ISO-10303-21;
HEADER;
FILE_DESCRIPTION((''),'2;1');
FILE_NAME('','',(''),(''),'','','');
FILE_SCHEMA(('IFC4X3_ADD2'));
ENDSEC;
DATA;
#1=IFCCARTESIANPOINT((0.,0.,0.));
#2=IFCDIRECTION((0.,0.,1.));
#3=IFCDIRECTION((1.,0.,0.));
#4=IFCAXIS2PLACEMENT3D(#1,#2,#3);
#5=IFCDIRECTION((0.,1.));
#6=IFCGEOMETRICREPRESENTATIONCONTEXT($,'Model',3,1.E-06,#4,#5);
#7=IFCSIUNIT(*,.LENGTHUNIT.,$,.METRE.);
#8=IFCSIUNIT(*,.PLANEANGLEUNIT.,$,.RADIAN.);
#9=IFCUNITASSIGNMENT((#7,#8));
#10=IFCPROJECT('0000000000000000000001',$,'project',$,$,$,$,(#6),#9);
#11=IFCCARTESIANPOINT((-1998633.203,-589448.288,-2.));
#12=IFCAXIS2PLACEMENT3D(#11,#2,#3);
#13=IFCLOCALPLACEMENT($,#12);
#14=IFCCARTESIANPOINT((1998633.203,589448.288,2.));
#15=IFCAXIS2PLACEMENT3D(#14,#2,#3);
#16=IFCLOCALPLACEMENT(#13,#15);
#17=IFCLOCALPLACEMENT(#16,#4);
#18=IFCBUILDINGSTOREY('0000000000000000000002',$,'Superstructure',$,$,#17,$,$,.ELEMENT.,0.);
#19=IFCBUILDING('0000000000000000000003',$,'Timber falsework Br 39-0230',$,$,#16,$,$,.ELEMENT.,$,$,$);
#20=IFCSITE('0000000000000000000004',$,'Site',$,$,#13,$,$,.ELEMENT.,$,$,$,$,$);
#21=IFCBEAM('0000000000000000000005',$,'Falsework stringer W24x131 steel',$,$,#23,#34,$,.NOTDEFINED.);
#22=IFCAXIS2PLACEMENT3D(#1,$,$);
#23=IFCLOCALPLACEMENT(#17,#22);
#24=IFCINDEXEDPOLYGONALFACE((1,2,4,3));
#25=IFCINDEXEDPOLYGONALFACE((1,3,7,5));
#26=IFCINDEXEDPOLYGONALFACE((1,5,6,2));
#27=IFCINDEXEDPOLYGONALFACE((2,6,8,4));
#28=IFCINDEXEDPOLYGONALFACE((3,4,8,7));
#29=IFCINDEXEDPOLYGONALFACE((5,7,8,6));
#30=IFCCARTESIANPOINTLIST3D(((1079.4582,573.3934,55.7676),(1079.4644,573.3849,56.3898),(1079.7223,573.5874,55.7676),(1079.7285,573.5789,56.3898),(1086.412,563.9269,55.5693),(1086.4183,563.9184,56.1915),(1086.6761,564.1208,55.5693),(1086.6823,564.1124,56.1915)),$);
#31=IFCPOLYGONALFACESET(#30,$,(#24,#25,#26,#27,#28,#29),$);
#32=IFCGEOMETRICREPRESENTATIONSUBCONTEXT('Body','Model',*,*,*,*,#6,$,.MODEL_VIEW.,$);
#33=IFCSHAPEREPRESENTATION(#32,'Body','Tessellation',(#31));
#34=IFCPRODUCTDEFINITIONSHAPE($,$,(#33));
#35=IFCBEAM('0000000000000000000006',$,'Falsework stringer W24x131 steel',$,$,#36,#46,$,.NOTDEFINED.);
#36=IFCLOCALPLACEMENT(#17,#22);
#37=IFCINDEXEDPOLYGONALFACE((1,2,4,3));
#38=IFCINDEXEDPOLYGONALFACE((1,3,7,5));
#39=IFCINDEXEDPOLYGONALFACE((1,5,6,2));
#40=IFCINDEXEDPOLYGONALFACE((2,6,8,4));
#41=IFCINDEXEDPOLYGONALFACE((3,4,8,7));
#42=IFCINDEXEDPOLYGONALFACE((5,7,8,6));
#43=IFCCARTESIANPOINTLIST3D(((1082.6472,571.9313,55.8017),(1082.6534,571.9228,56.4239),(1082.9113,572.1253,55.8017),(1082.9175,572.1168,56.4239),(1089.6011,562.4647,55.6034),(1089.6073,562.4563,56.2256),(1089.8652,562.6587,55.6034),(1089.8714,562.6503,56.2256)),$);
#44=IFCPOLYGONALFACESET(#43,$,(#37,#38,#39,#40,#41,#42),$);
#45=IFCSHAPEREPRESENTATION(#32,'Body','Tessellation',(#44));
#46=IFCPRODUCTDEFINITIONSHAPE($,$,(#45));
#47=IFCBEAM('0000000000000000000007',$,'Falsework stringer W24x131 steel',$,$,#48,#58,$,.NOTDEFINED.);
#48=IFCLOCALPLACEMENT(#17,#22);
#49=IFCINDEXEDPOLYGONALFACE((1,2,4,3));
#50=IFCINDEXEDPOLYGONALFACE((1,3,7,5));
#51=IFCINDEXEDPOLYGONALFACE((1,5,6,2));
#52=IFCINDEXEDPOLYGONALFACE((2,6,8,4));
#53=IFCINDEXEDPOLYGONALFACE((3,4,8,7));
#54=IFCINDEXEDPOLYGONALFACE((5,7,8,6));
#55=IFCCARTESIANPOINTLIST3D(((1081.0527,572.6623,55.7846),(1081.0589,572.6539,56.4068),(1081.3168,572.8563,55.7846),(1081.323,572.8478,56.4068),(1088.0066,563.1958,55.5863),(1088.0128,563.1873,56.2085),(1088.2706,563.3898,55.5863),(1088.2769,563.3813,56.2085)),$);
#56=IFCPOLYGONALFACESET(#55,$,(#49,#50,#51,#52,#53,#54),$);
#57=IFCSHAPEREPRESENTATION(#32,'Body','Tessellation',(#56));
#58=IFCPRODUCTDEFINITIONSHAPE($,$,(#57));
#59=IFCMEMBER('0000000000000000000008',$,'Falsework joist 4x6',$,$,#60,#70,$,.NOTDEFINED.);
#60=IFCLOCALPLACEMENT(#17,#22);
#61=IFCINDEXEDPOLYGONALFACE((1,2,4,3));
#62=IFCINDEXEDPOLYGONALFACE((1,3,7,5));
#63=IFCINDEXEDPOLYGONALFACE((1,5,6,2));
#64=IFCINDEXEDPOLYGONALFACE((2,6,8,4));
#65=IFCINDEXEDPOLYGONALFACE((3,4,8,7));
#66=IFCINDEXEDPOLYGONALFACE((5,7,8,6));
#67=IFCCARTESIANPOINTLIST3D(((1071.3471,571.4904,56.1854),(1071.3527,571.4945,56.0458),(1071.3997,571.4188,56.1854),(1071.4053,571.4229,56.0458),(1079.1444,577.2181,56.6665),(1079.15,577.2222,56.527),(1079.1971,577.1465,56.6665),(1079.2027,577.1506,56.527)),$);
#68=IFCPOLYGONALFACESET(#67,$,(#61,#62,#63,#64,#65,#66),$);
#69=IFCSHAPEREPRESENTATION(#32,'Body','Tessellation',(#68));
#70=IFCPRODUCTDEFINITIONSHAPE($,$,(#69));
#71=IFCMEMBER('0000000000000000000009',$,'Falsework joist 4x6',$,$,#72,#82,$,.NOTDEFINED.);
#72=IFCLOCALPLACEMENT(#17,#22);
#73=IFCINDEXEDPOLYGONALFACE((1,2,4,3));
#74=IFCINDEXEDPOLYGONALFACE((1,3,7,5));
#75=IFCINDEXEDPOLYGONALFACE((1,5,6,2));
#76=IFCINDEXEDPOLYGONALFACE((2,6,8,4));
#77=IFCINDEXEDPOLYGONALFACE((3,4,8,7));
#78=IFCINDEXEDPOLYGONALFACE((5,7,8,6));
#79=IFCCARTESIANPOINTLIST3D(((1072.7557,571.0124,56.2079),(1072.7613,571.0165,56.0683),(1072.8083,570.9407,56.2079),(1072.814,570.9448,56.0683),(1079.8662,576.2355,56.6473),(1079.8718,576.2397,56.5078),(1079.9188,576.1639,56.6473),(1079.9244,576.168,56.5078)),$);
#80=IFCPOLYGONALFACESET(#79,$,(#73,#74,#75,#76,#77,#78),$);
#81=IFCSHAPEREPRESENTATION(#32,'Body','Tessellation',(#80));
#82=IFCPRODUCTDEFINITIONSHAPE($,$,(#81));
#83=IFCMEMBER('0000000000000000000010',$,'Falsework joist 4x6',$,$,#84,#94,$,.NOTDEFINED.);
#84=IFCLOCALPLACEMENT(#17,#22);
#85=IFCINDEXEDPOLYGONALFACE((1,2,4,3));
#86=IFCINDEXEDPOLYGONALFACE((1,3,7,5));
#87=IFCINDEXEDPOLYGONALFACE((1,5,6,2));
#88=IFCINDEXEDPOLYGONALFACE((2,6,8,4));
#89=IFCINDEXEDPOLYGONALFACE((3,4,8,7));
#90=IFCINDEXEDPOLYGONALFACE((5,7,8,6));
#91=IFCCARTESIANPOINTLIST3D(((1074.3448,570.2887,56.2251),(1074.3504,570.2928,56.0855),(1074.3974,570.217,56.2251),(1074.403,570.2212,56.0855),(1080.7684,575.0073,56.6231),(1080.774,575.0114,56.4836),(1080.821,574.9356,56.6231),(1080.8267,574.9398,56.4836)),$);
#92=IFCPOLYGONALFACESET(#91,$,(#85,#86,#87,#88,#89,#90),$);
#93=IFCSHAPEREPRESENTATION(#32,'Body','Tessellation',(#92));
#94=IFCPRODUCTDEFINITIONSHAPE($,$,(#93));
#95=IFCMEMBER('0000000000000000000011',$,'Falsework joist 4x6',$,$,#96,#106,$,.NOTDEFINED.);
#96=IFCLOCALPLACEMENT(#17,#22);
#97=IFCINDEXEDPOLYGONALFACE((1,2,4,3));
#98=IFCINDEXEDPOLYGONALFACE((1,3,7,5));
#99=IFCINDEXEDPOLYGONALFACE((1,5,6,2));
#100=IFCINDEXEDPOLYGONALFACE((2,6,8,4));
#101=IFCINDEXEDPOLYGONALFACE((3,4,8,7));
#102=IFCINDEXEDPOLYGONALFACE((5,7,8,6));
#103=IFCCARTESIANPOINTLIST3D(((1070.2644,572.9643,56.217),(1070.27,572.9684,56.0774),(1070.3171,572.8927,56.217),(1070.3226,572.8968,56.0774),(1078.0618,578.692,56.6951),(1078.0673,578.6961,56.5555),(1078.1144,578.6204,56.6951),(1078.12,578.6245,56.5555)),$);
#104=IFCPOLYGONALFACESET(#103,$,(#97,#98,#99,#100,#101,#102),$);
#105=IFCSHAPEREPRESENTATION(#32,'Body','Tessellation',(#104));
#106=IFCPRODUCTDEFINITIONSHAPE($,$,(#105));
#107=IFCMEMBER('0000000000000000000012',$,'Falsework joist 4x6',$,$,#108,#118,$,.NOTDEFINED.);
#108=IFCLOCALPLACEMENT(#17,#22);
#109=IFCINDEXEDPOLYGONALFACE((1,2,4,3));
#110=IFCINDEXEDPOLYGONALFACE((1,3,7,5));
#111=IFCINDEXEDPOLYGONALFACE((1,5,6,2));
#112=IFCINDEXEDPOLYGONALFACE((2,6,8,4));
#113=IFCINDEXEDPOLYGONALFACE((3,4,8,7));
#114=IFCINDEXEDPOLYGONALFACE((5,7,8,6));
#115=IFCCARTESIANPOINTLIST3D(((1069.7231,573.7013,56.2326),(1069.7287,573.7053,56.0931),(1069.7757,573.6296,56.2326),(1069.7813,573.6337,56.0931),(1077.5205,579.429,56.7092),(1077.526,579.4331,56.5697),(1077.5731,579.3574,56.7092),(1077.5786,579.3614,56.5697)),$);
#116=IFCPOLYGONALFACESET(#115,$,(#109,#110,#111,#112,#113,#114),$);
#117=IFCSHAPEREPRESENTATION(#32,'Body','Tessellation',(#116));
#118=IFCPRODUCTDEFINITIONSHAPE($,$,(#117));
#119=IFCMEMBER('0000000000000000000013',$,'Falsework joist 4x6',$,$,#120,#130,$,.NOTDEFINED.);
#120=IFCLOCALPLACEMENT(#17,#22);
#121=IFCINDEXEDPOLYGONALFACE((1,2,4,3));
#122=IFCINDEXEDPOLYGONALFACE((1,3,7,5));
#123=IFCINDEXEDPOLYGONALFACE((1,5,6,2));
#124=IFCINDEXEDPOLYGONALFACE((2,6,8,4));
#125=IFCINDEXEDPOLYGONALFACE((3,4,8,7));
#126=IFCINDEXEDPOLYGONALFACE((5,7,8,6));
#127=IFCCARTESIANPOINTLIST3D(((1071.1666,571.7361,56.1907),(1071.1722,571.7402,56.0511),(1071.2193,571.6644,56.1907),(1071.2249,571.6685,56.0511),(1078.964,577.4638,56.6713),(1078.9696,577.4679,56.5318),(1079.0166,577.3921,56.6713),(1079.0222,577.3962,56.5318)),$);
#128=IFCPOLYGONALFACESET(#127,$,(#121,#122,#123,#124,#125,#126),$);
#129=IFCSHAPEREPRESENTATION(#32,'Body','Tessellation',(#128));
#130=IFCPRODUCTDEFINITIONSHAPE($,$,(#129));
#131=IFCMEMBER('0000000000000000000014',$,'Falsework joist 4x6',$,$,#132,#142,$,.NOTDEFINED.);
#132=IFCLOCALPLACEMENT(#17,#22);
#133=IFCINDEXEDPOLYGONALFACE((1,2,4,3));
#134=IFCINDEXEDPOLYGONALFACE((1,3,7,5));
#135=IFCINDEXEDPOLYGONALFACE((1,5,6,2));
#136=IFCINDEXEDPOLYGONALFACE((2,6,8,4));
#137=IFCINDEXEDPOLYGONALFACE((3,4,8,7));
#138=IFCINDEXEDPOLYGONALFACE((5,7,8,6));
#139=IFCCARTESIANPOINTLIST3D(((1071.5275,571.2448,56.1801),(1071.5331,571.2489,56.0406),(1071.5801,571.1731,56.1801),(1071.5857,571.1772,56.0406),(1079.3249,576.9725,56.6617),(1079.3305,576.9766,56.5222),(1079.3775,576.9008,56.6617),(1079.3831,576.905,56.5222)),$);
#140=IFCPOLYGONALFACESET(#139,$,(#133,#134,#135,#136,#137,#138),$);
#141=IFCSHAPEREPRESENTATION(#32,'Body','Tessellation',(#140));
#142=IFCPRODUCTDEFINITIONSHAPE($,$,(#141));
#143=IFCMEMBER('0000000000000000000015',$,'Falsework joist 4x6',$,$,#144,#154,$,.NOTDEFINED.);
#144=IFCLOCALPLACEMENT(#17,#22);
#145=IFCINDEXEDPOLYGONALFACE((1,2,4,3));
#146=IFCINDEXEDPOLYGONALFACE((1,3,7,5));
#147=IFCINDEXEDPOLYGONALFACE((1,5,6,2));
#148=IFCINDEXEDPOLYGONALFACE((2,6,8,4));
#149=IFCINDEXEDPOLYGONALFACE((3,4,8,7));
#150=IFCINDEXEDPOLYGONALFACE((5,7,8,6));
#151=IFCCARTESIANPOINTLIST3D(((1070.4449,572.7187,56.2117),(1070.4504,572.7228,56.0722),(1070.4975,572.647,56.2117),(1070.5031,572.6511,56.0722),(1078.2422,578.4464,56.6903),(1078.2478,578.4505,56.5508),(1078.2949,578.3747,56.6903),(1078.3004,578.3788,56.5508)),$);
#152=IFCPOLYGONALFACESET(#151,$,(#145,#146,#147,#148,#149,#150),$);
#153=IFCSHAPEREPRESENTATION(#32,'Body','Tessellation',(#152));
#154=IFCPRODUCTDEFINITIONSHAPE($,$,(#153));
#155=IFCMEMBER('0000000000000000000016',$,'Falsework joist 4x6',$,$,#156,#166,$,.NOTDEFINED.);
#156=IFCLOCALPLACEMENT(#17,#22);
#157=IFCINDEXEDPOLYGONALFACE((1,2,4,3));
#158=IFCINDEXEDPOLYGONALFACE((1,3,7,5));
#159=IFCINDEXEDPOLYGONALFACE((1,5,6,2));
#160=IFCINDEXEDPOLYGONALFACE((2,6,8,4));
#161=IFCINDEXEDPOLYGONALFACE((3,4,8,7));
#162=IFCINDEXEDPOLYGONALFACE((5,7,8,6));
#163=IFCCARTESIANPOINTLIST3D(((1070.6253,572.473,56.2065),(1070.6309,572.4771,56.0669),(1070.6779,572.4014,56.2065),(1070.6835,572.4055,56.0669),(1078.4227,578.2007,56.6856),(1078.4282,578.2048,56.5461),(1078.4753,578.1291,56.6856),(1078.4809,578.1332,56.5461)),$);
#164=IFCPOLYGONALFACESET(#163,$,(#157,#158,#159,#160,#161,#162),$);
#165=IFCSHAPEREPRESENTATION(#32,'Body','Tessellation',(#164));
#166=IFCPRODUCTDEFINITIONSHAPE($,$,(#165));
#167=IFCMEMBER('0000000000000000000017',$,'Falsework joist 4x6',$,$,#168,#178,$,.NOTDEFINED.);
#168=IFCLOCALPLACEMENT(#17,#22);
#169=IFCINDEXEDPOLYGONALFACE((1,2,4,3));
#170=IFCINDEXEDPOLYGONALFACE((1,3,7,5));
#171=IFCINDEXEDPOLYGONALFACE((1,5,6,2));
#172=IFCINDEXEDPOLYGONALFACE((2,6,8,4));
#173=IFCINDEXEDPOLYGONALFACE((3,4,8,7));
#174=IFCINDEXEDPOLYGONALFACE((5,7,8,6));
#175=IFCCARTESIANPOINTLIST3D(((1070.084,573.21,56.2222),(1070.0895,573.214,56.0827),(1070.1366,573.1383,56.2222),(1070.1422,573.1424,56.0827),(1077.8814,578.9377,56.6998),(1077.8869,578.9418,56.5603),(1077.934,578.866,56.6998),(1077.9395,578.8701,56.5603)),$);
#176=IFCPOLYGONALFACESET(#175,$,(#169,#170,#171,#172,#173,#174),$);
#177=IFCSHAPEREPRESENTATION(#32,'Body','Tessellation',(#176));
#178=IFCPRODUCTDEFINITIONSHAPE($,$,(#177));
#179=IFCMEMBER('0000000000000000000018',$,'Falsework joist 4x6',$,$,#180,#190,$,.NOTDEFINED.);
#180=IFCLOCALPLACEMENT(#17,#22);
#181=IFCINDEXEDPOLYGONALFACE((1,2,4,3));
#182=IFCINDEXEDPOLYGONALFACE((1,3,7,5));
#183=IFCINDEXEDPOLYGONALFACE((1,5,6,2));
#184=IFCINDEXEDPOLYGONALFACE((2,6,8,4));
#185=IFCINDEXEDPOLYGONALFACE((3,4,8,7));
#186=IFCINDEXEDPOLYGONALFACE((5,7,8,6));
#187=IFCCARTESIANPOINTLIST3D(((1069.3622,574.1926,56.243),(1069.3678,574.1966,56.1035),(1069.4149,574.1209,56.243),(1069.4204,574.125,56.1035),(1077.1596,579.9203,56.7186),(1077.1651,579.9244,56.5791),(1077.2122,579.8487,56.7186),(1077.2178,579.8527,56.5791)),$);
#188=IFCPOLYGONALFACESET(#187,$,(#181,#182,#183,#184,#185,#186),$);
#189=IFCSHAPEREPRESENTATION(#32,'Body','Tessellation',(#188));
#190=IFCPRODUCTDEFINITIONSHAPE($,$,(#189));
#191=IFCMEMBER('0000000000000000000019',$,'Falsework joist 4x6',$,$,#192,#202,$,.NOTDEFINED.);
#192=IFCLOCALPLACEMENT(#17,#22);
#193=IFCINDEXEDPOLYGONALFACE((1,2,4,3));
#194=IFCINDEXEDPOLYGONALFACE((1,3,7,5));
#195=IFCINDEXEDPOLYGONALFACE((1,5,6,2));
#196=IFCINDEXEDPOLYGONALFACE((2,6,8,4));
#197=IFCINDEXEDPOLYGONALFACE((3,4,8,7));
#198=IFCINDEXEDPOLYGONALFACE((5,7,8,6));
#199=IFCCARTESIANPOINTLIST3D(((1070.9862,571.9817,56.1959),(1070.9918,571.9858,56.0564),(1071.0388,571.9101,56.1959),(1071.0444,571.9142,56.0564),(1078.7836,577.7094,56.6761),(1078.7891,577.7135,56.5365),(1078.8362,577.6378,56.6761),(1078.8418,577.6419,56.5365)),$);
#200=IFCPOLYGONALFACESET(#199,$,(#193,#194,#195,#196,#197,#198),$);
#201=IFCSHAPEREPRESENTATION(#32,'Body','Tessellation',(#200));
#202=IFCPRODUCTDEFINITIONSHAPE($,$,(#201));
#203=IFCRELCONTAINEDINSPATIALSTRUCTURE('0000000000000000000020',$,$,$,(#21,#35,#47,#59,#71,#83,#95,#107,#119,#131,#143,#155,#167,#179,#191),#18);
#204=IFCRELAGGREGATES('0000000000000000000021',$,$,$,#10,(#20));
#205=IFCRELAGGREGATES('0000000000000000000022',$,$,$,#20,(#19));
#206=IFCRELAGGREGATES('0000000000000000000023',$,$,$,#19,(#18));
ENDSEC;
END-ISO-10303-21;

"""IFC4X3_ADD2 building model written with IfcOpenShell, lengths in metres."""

from ifc_helpers import new_model, si_unit, direction, frame, frame_2d, origin, origin_with_axes, place, context, subcontext, project, spatial, rectangle, extrude, element, save


model = new_model("IFC4X3_ADD2")

# Units and contexts
model_context = context("Model", 3, precision=1e-06, world=origin_with_axes(), true_north=direction((0.0, 1.0)))
body_context = subcontext(model_context, "Body", "Model", "MODEL_VIEW")
ifc_project = project(units=[si_unit("LENGTHUNIT", "METRE"), si_unit("PLANEANGLEUNIT", "RADIAN")], contexts=[model_context])

# Site, building, storey
site_placement = place(None, frame((-1998633.203, -589448.288, -2.0), z_axis=(0.0, 0.0, 1.0), x_axis=(1.0, 0.0, 0.0)))
site = spatial("IfcSite", under=ifc_project, at=site_placement, Name="Site", CompositionType="ELEMENT")
building_placement = place(site_placement, frame((1998633.203, 589448.288, 2.0), z_axis=(0.0, 0.0, 1.0), x_axis=(1.0, 0.0, 0.0)))
building = spatial("IfcBuilding", under=site, at=building_placement, Name="Timber falsework Br 39-0230", CompositionType="ELEMENT")
storey_placement = place(building_placement, origin_with_axes())
storey = spatial("IfcBuildingStorey", under=building, at=storey_placement, Name="Superstructure", CompositionType="ELEMENT", Elevation=0.0)

# Beams
beam_placement = place(storey_placement, frame((1079.5902, 573.4904, 55.7676), z_axis=(0.591929, -0.805813, -0.016879), x_axis=(0.805928, 0.592013, 0.0)))
element("IfcBeam", 1, at=beam_placement, inside=storey, Name="Falsework stringer W24x131 steel", PredefinedType="NOTDEFINED", context=body_context, shape_type="SweptSolid", body=[
    extrude(rectangle(XDim=0.3277, YDim=0.6223, at=frame_2d((0.0, 0.3111))), origin(), (0.0, 0.0, 1.0), 11.7478),
])
for number, where, z_axis, x_axis, name in (
    (2, (1082.7793, 572.0283, 55.8017), (0.591929, -0.805813, -0.016879), (0.805928, 0.592013, 0.0), "Falsework stringer W24x131 steel"),
    (3, (1081.1847, 572.7593, 55.7846), (0.591929, -0.805813, -0.016879), (0.805928, 0.592013, 0.0), "Falsework stringer W24x131 steel"),
):
    element("IfcBeam", number, at=place(storey_placement, frame(where, z_axis=z_axis, x_axis=x_axis)), inside=storey, Name=name, PredefinedType="NOTDEFINED", context=body_context, shape_type="SweptSolid", body=[
        extrude(rectangle(XDim=0.3277, YDim=0.6223, at=frame_2d((0.0, 0.3111))), origin(), (0.0, 0.0, 1.0), 11.7478),
    ])

# Members
member_1_placement = place(storey_placement, frame((1071.379, 571.4587, 56.0458), z_axis=(0.804934, 0.591282, 0.049669), x_axis=(-0.592013, 0.805928, 0.0)))
element("IfcMember", 4, at=member_1_placement, inside=storey, Name="Falsework joist 4x6", PredefinedType="NOTDEFINED", context=body_context, shape_type="SweptSolid", body=[
    extrude(rectangle(XDim=0.0889, YDim=0.1397, at=frame_2d((0.0, 0.0698))), origin(), (0.0, 0.0, 1.0), 9.687),
])
member_2_placement = place(storey_placement, frame((1072.7876, 570.9807, 56.0683), z_axis=(0.80493, 0.59128, 0.049747), x_axis=(-0.592013, 0.805928, 0.0)))
element("IfcMember", 5, at=member_2_placement, inside=storey, Name="Falsework joist 4x6", PredefinedType="NOTDEFINED", context=body_context, shape_type="SweptSolid", body=[
    extrude(rectangle(XDim=0.0889, YDim=0.1397, at=frame_2d((0.0, 0.0698))), origin(), (0.0, 0.0, 1.0), 8.8337),
])
member_3_placement = place(storey_placement, frame((1074.3767, 570.257, 56.0855), z_axis=(0.804925, 0.591276, 0.049876), x_axis=(-0.592013, 0.805928, 0.0)))
element("IfcMember", 6, at=member_3_placement, inside=storey, Name="Falsework joist 4x6", PredefinedType="NOTDEFINED", context=body_context, shape_type="SweptSolid", body=[
    extrude(rectangle(XDim=0.0889, YDim=0.1397, at=frame_2d((0.0, 0.0698))), origin(), (0.0, 0.0, 1.0), 7.9804),
])
member_4_placement = place(storey_placement, frame((1070.2963, 572.9326, 56.0774), z_axis=(0.804946, 0.591292, 0.049358), x_axis=(-0.592013, 0.805928, 0.0)))
element("IfcMember", 7, at=member_4_placement, inside=storey, Name="Falsework joist 4x6", PredefinedType="NOTDEFINED", context=body_context, shape_type="SweptSolid", body=[
    extrude(rectangle(XDim=0.0889, YDim=0.1397, at=frame_2d((0.0, 0.0698))), origin(), (0.0, 0.0, 1.0), 9.6868),
])
member_5_placement = place(storey_placement, frame((1069.755, 573.6695, 56.0931), z_axis=(0.804952, 0.591296, 0.049202), x_axis=(-0.592013, 0.805928, 0.0)))
element("IfcMember", 8, at=member_5_placement, inside=storey, Name="Falsework joist 4x6", PredefinedType="NOTDEFINED", context=body_context, shape_type="SweptSolid", body=[
    extrude(rectangle(XDim=0.0889, YDim=0.1397, at=frame_2d((0.0, 0.0698))), origin(), (0.0, 0.0, 1.0), 9.6867),
])
member_6_placement = place(storey_placement, frame((1071.1985, 571.7043, 56.0511), z_axis=(0.804936, 0.591284, 0.049617), x_axis=(-0.592013, 0.805928, 0.0)))
element("IfcMember", 9, at=member_6_placement, inside=storey, Name="Falsework joist 4x6", PredefinedType="NOTDEFINED", context=body_context, shape_type="SweptSolid", body=[
    extrude(rectangle(XDim=0.0889, YDim=0.1397, at=frame_2d((0.0, 0.0698))), origin(), (0.0, 0.0, 1.0), 9.6869),
])
member_7_placement = place(storey_placement, frame((1071.5594, 571.213, 56.0406), z_axis=(0.804931, 0.591281, 0.049721), x_axis=(-0.592013, 0.805928, 0.0)))
element("IfcMember", 10, at=member_7_placement, inside=storey, Name="Falsework joist 4x6", PredefinedType="NOTDEFINED", context=body_context, shape_type="SweptSolid", body=[
    extrude(rectangle(XDim=0.0889, YDim=0.1397, at=frame_2d((0.0, 0.0698))), origin(), (0.0, 0.0, 1.0), 9.687),
])
member_8_placement = place(storey_placement, frame((1070.4768, 572.6869, 56.0722), z_axis=(0.804944, 0.59129, 0.04941), x_axis=(-0.592013, 0.805928, 0.0)))
element("IfcMember", 11, at=member_8_placement, inside=storey, Name="Falsework joist 4x6", PredefinedType="NOTDEFINED", context=body_context, shape_type="SweptSolid", body=[
    extrude(rectangle(XDim=0.0889, YDim=0.1397, at=frame_2d((0.0, 0.0698))), origin(), (0.0, 0.0, 1.0), 9.6868),
])
member_9_placement = place(storey_placement, frame((1070.6572, 572.4413, 56.0669), z_axis=(0.804942, 0.591289, 0.049462), x_axis=(-0.592013, 0.805928, 0.0)))
element("IfcMember", 12, at=member_9_placement, inside=storey, Name="Falsework joist 4x6", PredefinedType="NOTDEFINED", context=body_context, shape_type="SweptSolid", body=[
    extrude(rectangle(XDim=0.0889, YDim=0.1397, at=frame_2d((0.0, 0.0698))), origin(), (0.0, 0.0, 1.0), 9.6869),
])
member_10_placement = place(storey_placement, frame((1070.1159, 573.1782, 56.0827), z_axis=(0.804948, 0.591293, 0.049306), x_axis=(-0.592013, 0.805928, 0.0)))
element("IfcMember", 13, at=member_10_placement, inside=storey, Name="Falsework joist 4x6", PredefinedType="NOTDEFINED", context=body_context, shape_type="SweptSolid", body=[
    extrude(rectangle(XDim=0.0889, YDim=0.1397, at=frame_2d((0.0, 0.0698))), origin(), (0.0, 0.0, 1.0), 9.6868),
])
member_11_placement = place(storey_placement, frame((1069.3941, 574.1608, 56.1035), z_axis=(0.804956, 0.591299, 0.049098), x_axis=(-0.592013, 0.805928, 0.0)))
element("IfcMember", 14, at=member_11_placement, inside=storey, Name="Falsework joist 4x6", PredefinedType="NOTDEFINED", context=body_context, shape_type="SweptSolid", body=[
    extrude(rectangle(XDim=0.0889, YDim=0.1397, at=frame_2d((0.0, 0.0698))), origin(), (0.0, 0.0, 1.0), 9.6867),
])
member_12_placement = place(storey_placement, frame((1071.0181, 571.95, 56.0564), z_axis=(0.804938, 0.591286, 0.049566), x_axis=(-0.592013, 0.805928, 0.0)))
element("IfcMember", 15, at=member_12_placement, inside=storey, Name="Falsework joist 4x6", PredefinedType="NOTDEFINED", context=body_context, shape_type="SweptSolid", body=[
    extrude(rectangle(XDim=0.0889, YDim=0.1397, at=frame_2d((0.0, 0.0698))), origin(), (0.0, 0.0, 1.0), 9.6869),
])

save(model, "model.ifc")
